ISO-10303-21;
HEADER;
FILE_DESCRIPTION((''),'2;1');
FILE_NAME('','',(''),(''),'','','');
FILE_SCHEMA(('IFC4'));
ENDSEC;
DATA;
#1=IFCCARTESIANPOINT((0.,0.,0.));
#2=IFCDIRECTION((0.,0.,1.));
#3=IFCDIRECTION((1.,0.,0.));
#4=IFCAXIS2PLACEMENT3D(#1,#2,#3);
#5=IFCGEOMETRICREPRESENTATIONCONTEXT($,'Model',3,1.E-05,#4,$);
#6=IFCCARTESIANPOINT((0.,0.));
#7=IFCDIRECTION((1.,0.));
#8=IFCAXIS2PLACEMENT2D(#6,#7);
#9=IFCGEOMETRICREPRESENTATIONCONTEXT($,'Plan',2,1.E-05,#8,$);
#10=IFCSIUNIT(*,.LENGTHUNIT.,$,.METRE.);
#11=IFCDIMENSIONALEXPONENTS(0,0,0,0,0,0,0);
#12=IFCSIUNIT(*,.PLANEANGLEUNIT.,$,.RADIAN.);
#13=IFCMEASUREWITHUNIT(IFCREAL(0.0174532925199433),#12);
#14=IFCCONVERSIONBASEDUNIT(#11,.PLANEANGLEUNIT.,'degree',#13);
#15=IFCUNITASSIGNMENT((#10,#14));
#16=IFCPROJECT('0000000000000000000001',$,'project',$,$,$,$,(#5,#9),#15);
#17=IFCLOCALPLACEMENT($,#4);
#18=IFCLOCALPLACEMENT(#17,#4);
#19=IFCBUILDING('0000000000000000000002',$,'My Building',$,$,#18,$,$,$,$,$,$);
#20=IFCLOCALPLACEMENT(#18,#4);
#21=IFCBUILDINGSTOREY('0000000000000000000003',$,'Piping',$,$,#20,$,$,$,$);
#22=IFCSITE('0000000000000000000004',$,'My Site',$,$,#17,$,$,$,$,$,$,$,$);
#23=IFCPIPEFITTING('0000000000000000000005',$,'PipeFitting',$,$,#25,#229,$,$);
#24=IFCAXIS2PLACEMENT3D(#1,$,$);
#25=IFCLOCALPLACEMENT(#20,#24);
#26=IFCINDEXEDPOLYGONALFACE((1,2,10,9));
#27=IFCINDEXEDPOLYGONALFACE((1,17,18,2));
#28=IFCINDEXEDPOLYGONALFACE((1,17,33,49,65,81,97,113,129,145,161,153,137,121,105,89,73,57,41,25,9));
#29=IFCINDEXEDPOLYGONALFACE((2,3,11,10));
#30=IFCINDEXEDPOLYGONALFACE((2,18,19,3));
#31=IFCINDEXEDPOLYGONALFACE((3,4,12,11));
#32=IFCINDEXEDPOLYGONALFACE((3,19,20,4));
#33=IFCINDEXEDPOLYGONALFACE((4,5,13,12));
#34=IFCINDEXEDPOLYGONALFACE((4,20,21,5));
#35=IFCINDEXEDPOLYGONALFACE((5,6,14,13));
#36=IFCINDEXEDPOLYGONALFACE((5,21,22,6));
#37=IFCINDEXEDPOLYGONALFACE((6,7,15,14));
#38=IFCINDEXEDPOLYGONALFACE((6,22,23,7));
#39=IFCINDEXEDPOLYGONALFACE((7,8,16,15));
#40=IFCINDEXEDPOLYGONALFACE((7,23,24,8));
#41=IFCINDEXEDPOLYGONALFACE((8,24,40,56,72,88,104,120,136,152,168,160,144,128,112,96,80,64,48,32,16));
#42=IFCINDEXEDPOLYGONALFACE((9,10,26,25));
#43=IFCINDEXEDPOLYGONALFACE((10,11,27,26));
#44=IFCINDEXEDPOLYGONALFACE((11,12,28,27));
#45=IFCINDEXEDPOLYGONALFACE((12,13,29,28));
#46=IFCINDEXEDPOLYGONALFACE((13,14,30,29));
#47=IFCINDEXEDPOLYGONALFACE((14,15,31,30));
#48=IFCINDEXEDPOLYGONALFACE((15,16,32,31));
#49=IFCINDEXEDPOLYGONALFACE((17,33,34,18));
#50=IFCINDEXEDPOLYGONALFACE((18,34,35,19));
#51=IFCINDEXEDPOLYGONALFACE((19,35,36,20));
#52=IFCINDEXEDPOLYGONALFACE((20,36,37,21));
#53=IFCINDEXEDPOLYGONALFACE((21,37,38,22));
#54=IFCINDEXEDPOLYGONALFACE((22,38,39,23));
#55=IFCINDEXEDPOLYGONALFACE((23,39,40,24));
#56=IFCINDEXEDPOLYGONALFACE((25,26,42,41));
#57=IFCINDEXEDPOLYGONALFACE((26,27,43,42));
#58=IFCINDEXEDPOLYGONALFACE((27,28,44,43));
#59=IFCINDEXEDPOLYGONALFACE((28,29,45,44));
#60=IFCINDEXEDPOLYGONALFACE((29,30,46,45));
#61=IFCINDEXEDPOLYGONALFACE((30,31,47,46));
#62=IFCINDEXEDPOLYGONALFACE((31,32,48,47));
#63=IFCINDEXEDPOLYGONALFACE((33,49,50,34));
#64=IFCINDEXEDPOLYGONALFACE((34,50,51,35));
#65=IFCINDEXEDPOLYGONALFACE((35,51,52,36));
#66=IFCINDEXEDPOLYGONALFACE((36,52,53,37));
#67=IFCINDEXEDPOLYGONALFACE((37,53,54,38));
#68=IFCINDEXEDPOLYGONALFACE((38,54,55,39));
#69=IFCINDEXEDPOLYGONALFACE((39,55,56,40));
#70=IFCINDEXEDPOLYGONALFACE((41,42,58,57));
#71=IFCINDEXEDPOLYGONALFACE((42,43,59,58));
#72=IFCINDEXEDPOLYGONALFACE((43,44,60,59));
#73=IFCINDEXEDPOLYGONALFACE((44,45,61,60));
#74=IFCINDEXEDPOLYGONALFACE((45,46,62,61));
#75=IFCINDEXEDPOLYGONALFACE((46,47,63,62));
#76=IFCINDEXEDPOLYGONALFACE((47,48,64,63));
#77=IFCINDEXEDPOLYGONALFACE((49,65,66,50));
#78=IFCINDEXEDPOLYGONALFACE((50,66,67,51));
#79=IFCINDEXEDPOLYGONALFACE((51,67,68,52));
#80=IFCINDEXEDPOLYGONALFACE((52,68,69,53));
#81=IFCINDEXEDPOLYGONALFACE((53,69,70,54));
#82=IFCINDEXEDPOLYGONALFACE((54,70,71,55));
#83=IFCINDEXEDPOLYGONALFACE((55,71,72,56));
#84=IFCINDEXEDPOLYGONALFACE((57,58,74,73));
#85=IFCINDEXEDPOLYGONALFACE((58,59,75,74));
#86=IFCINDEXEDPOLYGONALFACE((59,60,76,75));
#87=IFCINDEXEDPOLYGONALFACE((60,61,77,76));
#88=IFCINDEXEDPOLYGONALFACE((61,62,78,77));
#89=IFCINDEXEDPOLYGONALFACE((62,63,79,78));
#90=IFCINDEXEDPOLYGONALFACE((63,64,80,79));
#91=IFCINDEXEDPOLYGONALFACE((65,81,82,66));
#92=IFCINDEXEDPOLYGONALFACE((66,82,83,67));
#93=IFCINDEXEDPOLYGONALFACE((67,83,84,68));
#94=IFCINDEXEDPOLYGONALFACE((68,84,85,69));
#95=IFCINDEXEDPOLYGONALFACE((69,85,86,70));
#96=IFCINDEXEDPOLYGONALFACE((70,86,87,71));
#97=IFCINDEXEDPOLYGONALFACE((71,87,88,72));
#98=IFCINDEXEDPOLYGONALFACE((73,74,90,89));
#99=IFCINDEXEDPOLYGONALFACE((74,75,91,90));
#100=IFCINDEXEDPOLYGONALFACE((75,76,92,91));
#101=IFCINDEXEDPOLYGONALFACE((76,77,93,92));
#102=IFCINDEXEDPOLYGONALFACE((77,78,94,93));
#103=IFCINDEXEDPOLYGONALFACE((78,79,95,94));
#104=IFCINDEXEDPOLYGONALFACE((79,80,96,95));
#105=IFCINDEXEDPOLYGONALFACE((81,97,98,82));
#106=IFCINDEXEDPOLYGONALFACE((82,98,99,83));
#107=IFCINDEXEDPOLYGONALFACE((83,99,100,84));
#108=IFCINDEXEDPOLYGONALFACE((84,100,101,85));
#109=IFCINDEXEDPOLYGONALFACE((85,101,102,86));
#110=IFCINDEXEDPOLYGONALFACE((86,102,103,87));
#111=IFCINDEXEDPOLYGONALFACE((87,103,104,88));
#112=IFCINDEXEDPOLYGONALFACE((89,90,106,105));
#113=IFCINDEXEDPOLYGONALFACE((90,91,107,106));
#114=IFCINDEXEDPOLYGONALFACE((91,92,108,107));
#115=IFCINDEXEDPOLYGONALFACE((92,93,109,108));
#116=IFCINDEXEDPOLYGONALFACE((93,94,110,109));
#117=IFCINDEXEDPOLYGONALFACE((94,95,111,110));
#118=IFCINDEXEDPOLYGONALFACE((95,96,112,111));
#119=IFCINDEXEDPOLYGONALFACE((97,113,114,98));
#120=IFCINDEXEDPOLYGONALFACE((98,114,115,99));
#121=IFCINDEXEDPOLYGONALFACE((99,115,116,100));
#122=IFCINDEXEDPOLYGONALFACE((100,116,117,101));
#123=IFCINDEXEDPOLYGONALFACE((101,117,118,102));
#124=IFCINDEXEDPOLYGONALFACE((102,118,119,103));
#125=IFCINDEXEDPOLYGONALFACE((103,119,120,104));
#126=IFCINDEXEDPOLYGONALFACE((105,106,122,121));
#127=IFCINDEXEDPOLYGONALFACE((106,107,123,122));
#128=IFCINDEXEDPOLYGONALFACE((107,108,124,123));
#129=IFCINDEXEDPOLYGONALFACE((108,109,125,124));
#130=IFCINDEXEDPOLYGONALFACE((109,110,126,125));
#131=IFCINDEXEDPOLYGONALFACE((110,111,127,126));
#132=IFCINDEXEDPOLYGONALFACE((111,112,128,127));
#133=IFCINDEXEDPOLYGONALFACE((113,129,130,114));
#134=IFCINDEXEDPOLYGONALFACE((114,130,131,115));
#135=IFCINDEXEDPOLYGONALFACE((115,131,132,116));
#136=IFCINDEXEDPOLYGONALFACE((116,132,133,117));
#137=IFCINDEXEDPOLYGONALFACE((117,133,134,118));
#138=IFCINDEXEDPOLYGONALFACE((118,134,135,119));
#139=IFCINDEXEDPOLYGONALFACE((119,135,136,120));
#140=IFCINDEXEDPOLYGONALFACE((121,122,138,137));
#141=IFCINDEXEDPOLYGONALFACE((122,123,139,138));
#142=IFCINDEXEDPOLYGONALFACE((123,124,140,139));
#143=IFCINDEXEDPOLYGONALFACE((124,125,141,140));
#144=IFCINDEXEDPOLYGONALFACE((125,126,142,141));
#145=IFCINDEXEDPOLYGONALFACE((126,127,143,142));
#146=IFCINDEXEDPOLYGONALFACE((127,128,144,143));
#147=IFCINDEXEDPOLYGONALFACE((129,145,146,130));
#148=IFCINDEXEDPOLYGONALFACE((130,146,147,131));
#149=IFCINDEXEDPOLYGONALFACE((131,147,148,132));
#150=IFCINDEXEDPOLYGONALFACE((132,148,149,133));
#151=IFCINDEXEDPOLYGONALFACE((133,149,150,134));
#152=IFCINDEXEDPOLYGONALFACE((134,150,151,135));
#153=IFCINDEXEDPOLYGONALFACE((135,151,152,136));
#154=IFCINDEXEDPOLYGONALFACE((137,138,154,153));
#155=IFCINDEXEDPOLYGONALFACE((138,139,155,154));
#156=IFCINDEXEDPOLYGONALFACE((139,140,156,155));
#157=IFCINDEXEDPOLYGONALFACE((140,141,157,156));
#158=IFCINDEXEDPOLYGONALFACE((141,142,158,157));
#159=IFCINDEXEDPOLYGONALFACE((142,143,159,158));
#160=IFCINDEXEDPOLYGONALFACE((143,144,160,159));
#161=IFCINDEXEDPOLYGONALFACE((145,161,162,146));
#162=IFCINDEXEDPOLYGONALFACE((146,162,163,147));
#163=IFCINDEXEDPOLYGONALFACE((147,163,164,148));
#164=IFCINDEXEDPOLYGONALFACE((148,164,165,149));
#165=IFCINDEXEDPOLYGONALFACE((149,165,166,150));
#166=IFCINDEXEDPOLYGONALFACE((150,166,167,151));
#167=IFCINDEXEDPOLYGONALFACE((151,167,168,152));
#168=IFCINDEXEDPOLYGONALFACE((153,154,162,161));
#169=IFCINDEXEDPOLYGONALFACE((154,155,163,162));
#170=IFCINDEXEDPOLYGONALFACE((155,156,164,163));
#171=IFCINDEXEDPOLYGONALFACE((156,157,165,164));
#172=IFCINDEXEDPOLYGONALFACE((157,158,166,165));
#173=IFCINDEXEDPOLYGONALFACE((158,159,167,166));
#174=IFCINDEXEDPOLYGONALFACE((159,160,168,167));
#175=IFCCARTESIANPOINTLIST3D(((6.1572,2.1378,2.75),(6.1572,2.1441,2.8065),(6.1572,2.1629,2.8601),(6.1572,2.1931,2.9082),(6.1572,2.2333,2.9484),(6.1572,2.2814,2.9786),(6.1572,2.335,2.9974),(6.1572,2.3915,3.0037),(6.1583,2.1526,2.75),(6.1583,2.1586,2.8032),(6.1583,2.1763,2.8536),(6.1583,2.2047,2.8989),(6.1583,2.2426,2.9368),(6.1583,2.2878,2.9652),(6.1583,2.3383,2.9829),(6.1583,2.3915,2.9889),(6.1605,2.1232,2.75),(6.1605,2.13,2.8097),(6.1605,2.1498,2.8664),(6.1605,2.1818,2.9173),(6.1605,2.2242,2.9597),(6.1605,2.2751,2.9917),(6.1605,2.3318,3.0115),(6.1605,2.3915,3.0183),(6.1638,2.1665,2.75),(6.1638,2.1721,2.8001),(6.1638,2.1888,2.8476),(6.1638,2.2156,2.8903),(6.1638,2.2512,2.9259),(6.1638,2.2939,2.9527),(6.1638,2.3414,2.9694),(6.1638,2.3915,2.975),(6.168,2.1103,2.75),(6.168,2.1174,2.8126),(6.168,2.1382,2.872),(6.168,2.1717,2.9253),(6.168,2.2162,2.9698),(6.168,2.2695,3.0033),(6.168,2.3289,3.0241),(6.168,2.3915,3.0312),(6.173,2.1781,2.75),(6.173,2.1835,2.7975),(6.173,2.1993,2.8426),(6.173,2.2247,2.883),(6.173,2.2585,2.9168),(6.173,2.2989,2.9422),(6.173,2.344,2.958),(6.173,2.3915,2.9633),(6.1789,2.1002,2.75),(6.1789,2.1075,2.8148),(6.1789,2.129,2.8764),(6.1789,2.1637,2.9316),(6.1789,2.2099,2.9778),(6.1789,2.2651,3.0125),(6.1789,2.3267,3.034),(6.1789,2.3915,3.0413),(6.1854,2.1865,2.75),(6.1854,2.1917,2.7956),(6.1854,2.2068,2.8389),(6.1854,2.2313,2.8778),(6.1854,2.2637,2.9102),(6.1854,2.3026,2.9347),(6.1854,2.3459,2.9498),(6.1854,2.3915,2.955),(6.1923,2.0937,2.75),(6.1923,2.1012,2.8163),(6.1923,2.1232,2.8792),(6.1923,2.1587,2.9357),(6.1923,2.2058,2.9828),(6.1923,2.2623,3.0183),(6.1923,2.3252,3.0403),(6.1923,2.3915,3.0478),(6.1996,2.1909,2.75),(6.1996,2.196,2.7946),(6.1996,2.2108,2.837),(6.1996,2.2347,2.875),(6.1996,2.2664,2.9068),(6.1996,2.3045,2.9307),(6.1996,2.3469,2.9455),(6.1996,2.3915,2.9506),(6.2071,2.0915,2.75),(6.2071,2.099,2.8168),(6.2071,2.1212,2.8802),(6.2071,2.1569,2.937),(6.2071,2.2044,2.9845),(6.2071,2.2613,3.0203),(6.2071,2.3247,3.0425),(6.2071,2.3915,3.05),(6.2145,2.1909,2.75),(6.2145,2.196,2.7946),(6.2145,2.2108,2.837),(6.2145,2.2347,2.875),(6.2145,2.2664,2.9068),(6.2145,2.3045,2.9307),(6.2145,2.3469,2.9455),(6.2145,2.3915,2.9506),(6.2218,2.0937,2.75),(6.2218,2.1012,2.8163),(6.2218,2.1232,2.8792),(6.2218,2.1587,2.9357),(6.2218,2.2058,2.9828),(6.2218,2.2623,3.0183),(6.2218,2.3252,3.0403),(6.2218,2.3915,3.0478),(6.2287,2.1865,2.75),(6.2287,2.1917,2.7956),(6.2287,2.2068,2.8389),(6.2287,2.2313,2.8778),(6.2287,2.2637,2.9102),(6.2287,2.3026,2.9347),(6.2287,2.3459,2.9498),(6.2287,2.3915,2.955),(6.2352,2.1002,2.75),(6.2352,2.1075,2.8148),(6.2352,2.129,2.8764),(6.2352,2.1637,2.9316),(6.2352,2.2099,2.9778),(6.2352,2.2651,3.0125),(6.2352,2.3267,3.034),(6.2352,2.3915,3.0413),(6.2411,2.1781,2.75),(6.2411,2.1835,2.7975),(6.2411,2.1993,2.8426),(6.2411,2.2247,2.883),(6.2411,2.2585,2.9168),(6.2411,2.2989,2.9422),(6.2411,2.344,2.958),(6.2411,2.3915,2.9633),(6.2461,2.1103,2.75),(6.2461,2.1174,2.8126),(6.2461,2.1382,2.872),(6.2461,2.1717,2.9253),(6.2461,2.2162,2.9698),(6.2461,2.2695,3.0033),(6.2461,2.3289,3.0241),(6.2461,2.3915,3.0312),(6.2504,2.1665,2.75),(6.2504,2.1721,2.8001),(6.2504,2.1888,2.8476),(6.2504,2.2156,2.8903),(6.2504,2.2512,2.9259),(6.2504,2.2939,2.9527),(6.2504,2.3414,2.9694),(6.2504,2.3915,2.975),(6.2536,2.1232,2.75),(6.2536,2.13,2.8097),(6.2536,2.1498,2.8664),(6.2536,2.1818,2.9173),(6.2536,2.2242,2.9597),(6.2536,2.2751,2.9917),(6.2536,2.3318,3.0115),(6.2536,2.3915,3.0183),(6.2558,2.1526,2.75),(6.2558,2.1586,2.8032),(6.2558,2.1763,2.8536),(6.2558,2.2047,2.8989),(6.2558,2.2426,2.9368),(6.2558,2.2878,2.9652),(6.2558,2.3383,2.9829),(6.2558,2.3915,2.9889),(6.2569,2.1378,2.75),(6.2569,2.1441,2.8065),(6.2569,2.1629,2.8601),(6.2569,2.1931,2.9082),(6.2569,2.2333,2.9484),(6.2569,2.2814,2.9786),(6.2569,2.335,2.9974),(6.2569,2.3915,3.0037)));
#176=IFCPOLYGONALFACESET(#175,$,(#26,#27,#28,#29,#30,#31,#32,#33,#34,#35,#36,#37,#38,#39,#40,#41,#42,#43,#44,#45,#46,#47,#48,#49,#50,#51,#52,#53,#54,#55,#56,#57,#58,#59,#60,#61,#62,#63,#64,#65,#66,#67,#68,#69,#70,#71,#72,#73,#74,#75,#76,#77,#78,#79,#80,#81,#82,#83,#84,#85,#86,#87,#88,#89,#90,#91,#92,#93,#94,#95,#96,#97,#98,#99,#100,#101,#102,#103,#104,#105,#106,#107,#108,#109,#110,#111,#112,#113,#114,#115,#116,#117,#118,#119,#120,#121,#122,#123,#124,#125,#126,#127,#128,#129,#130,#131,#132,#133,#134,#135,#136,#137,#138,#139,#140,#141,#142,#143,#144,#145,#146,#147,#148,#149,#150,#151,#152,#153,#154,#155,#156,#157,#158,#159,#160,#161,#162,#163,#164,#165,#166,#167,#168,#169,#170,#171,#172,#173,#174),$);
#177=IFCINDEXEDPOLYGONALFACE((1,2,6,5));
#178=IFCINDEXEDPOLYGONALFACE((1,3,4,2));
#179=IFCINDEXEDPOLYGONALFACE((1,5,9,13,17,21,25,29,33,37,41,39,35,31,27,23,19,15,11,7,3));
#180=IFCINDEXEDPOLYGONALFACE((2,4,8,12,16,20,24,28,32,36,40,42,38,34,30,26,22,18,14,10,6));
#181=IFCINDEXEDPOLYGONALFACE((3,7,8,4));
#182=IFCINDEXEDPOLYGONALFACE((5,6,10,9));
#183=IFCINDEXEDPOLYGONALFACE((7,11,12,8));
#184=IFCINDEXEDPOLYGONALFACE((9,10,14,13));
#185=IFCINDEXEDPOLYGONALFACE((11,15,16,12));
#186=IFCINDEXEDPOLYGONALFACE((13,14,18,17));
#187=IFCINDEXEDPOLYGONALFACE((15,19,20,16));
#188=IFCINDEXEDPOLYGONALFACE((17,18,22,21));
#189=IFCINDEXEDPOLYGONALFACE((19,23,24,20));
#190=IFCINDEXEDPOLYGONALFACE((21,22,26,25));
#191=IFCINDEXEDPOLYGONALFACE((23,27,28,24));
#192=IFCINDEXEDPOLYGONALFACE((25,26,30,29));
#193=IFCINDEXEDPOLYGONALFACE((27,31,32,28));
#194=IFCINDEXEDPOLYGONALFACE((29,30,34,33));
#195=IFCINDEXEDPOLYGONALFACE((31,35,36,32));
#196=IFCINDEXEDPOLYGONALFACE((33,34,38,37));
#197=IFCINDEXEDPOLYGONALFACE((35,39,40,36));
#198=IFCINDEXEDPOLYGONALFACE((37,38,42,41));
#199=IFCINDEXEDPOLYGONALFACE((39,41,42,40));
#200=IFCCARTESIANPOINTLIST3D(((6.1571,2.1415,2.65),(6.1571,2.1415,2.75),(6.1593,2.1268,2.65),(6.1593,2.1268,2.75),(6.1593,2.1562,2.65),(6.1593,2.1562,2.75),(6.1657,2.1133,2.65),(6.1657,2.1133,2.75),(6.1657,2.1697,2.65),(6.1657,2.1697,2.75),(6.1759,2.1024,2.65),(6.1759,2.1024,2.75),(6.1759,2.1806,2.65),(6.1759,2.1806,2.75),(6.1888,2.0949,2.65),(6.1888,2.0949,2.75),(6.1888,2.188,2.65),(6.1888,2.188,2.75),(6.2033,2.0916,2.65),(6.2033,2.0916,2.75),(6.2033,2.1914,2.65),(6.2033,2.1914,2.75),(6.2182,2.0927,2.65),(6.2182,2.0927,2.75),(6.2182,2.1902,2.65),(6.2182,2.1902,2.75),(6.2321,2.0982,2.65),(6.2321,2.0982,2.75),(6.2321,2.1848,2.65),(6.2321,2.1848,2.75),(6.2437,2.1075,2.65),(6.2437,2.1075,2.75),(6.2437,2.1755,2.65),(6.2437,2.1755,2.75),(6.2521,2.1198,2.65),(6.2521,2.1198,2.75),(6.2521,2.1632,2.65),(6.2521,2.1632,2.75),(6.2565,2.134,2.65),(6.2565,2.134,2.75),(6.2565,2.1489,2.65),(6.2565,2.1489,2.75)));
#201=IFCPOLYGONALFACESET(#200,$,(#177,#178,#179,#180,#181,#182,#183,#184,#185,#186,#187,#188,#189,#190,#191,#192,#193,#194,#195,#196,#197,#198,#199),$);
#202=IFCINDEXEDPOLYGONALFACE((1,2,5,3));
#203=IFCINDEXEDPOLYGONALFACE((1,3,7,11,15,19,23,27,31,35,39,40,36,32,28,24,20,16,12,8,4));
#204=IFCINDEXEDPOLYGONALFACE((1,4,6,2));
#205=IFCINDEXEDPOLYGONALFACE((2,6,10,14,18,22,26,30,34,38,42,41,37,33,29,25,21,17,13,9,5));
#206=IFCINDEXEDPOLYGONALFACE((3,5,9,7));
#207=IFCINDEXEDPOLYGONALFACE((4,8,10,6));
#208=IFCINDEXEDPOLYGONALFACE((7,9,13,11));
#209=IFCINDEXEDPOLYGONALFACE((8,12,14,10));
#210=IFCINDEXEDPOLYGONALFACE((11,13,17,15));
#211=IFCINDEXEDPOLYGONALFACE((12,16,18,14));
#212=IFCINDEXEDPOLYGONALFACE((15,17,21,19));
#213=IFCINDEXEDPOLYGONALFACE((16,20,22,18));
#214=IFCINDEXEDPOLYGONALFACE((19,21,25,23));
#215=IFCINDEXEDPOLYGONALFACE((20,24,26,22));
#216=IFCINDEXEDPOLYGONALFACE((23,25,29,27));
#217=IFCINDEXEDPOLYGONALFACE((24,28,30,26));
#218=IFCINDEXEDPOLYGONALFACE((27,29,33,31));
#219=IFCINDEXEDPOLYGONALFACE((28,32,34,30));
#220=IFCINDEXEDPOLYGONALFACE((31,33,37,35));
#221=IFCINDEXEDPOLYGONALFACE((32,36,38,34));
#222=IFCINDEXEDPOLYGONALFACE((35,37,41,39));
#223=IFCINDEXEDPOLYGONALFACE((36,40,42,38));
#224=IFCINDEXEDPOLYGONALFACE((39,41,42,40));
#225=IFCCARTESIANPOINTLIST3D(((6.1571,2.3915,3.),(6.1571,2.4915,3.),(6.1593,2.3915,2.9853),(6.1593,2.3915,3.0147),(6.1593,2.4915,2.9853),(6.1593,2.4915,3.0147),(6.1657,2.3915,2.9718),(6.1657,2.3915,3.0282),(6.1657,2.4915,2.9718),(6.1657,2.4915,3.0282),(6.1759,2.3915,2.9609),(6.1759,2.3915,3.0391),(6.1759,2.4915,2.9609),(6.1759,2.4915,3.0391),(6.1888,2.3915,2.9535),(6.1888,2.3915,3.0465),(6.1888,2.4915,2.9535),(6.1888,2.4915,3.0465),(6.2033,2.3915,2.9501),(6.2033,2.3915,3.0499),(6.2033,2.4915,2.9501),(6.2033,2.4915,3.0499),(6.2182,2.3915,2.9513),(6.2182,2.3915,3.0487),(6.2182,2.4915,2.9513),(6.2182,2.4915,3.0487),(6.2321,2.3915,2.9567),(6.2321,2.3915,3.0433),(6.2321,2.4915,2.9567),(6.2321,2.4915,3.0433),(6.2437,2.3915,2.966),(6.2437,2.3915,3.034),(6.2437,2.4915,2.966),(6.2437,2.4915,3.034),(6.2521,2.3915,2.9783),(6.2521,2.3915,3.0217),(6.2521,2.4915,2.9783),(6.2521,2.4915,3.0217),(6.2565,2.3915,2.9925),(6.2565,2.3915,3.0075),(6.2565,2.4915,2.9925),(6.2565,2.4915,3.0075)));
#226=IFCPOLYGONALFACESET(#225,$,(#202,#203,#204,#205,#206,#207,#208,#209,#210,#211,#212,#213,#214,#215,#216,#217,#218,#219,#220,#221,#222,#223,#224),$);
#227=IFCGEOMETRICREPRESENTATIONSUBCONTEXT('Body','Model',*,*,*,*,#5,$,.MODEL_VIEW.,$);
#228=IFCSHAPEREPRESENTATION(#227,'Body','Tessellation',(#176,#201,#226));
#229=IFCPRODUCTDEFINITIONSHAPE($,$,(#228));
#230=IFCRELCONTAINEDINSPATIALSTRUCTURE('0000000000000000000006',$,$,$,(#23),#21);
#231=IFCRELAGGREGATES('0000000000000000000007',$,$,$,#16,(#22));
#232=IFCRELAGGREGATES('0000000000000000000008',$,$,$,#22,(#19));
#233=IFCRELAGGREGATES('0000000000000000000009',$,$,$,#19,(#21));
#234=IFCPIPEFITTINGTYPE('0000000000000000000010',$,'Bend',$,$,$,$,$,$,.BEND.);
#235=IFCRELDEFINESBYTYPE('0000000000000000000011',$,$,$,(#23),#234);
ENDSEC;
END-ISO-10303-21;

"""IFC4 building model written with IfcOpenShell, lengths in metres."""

from ifc_helpers import new_model, entity, si_unit, converted_unit, frame, origin_with_axes, origin_2d_with_axis, place, context, subcontext, project, spatial, circle, extrude, source, transform, mapped, type_object, type_shapes, element, save


model = new_model("IFC4")

# Units and contexts
model_context = context("Model", 3, precision=1e-05, world=origin_with_axes())
plan_context = context("Plan", 2, precision=1e-05, world=origin_2d_with_axis())
body_context = subcontext(model_context, "Body", "Model", "MODEL_VIEW")
ifc_project = project(units=[si_unit("LENGTHUNIT", "METRE"), converted_unit("PLANEANGLEUNIT", "degree", entity("IfcReal", 0.0174532925199433), si_unit("PLANEANGLEUNIT", "RADIAN"), dimensions=[0, 0, 0, 0, 0, 0, 0])], contexts=[model_context, plan_context])

# Site, building, storey
site_placement = place(None, origin_with_axes())
site = spatial("IfcSite", under=ifc_project, at=site_placement, Name="My Site")
building_placement = place(site_placement, origin_with_axes())
building = spatial("IfcBuilding", under=site, at=building_placement, Name="My Building")
storey_placement = place(building_placement, origin_with_axes())
storey = spatial("IfcBuildingStorey", under=building, at=storey_placement, Name="Piping")

# Pipe fitting
pipe_fitting_type_1 = type_object("IfcPipeFittingType", Name="Bend", PredefinedType="BEND")
shared_shape = source(origin_with_axes(), body_context, "Body", "SolidModel", [
    entity("IfcSweptDiskSolid", entity("IfcIndexedPolyCurve", entity("IfcCartesianPointList3D", [[0.0, 0.0, -0.1], [0.0, 0.0732, -0.2768], [0.0, 0.25, -0.35]]), [entity("IfcArcIndex", [1, 2, 3])]), 0.05),
    extrude(circle(Radius=0.05), origin_with_axes(), (0.0, 0.0, -1.0), 0.1),
    extrude(circle(Radius=0.05), frame((0.0, 0.25, -0.35), z_axis=(0.0, 1.0, 0.0), x_axis=(1.0, 0.0, 0.0)), (0.0, 0.0, 1.0), 0.1),
])
type_shapes(pipe_fitting_type_1, [shared_shape])
for number, where, z_axis, x_axis, name in (
    (1, (6.2071, 2.1415, 2.65), (0.0, 0.0, -1.0), (-1.0, 0.0, 0.0), "PipeFitting"),
):
    element("IfcPipeFitting", number, at=place(storey_placement, frame(where, z_axis=z_axis, x_axis=x_axis)), inside=storey, type_object=pipe_fitting_type_1, Name=name, context=body_context, shape_type="MappedRepresentation", body=[
        mapped(shared_shape, transform((0.0, 0.0, 0.0), x_axis=(1.0, 0.0, 0.0), y_axis=(0.0, 1.0, 0.0), z_axis=(0.0, 0.0, 1.0), scale=1.0)),
    ])

save(model, "model.ifc")
